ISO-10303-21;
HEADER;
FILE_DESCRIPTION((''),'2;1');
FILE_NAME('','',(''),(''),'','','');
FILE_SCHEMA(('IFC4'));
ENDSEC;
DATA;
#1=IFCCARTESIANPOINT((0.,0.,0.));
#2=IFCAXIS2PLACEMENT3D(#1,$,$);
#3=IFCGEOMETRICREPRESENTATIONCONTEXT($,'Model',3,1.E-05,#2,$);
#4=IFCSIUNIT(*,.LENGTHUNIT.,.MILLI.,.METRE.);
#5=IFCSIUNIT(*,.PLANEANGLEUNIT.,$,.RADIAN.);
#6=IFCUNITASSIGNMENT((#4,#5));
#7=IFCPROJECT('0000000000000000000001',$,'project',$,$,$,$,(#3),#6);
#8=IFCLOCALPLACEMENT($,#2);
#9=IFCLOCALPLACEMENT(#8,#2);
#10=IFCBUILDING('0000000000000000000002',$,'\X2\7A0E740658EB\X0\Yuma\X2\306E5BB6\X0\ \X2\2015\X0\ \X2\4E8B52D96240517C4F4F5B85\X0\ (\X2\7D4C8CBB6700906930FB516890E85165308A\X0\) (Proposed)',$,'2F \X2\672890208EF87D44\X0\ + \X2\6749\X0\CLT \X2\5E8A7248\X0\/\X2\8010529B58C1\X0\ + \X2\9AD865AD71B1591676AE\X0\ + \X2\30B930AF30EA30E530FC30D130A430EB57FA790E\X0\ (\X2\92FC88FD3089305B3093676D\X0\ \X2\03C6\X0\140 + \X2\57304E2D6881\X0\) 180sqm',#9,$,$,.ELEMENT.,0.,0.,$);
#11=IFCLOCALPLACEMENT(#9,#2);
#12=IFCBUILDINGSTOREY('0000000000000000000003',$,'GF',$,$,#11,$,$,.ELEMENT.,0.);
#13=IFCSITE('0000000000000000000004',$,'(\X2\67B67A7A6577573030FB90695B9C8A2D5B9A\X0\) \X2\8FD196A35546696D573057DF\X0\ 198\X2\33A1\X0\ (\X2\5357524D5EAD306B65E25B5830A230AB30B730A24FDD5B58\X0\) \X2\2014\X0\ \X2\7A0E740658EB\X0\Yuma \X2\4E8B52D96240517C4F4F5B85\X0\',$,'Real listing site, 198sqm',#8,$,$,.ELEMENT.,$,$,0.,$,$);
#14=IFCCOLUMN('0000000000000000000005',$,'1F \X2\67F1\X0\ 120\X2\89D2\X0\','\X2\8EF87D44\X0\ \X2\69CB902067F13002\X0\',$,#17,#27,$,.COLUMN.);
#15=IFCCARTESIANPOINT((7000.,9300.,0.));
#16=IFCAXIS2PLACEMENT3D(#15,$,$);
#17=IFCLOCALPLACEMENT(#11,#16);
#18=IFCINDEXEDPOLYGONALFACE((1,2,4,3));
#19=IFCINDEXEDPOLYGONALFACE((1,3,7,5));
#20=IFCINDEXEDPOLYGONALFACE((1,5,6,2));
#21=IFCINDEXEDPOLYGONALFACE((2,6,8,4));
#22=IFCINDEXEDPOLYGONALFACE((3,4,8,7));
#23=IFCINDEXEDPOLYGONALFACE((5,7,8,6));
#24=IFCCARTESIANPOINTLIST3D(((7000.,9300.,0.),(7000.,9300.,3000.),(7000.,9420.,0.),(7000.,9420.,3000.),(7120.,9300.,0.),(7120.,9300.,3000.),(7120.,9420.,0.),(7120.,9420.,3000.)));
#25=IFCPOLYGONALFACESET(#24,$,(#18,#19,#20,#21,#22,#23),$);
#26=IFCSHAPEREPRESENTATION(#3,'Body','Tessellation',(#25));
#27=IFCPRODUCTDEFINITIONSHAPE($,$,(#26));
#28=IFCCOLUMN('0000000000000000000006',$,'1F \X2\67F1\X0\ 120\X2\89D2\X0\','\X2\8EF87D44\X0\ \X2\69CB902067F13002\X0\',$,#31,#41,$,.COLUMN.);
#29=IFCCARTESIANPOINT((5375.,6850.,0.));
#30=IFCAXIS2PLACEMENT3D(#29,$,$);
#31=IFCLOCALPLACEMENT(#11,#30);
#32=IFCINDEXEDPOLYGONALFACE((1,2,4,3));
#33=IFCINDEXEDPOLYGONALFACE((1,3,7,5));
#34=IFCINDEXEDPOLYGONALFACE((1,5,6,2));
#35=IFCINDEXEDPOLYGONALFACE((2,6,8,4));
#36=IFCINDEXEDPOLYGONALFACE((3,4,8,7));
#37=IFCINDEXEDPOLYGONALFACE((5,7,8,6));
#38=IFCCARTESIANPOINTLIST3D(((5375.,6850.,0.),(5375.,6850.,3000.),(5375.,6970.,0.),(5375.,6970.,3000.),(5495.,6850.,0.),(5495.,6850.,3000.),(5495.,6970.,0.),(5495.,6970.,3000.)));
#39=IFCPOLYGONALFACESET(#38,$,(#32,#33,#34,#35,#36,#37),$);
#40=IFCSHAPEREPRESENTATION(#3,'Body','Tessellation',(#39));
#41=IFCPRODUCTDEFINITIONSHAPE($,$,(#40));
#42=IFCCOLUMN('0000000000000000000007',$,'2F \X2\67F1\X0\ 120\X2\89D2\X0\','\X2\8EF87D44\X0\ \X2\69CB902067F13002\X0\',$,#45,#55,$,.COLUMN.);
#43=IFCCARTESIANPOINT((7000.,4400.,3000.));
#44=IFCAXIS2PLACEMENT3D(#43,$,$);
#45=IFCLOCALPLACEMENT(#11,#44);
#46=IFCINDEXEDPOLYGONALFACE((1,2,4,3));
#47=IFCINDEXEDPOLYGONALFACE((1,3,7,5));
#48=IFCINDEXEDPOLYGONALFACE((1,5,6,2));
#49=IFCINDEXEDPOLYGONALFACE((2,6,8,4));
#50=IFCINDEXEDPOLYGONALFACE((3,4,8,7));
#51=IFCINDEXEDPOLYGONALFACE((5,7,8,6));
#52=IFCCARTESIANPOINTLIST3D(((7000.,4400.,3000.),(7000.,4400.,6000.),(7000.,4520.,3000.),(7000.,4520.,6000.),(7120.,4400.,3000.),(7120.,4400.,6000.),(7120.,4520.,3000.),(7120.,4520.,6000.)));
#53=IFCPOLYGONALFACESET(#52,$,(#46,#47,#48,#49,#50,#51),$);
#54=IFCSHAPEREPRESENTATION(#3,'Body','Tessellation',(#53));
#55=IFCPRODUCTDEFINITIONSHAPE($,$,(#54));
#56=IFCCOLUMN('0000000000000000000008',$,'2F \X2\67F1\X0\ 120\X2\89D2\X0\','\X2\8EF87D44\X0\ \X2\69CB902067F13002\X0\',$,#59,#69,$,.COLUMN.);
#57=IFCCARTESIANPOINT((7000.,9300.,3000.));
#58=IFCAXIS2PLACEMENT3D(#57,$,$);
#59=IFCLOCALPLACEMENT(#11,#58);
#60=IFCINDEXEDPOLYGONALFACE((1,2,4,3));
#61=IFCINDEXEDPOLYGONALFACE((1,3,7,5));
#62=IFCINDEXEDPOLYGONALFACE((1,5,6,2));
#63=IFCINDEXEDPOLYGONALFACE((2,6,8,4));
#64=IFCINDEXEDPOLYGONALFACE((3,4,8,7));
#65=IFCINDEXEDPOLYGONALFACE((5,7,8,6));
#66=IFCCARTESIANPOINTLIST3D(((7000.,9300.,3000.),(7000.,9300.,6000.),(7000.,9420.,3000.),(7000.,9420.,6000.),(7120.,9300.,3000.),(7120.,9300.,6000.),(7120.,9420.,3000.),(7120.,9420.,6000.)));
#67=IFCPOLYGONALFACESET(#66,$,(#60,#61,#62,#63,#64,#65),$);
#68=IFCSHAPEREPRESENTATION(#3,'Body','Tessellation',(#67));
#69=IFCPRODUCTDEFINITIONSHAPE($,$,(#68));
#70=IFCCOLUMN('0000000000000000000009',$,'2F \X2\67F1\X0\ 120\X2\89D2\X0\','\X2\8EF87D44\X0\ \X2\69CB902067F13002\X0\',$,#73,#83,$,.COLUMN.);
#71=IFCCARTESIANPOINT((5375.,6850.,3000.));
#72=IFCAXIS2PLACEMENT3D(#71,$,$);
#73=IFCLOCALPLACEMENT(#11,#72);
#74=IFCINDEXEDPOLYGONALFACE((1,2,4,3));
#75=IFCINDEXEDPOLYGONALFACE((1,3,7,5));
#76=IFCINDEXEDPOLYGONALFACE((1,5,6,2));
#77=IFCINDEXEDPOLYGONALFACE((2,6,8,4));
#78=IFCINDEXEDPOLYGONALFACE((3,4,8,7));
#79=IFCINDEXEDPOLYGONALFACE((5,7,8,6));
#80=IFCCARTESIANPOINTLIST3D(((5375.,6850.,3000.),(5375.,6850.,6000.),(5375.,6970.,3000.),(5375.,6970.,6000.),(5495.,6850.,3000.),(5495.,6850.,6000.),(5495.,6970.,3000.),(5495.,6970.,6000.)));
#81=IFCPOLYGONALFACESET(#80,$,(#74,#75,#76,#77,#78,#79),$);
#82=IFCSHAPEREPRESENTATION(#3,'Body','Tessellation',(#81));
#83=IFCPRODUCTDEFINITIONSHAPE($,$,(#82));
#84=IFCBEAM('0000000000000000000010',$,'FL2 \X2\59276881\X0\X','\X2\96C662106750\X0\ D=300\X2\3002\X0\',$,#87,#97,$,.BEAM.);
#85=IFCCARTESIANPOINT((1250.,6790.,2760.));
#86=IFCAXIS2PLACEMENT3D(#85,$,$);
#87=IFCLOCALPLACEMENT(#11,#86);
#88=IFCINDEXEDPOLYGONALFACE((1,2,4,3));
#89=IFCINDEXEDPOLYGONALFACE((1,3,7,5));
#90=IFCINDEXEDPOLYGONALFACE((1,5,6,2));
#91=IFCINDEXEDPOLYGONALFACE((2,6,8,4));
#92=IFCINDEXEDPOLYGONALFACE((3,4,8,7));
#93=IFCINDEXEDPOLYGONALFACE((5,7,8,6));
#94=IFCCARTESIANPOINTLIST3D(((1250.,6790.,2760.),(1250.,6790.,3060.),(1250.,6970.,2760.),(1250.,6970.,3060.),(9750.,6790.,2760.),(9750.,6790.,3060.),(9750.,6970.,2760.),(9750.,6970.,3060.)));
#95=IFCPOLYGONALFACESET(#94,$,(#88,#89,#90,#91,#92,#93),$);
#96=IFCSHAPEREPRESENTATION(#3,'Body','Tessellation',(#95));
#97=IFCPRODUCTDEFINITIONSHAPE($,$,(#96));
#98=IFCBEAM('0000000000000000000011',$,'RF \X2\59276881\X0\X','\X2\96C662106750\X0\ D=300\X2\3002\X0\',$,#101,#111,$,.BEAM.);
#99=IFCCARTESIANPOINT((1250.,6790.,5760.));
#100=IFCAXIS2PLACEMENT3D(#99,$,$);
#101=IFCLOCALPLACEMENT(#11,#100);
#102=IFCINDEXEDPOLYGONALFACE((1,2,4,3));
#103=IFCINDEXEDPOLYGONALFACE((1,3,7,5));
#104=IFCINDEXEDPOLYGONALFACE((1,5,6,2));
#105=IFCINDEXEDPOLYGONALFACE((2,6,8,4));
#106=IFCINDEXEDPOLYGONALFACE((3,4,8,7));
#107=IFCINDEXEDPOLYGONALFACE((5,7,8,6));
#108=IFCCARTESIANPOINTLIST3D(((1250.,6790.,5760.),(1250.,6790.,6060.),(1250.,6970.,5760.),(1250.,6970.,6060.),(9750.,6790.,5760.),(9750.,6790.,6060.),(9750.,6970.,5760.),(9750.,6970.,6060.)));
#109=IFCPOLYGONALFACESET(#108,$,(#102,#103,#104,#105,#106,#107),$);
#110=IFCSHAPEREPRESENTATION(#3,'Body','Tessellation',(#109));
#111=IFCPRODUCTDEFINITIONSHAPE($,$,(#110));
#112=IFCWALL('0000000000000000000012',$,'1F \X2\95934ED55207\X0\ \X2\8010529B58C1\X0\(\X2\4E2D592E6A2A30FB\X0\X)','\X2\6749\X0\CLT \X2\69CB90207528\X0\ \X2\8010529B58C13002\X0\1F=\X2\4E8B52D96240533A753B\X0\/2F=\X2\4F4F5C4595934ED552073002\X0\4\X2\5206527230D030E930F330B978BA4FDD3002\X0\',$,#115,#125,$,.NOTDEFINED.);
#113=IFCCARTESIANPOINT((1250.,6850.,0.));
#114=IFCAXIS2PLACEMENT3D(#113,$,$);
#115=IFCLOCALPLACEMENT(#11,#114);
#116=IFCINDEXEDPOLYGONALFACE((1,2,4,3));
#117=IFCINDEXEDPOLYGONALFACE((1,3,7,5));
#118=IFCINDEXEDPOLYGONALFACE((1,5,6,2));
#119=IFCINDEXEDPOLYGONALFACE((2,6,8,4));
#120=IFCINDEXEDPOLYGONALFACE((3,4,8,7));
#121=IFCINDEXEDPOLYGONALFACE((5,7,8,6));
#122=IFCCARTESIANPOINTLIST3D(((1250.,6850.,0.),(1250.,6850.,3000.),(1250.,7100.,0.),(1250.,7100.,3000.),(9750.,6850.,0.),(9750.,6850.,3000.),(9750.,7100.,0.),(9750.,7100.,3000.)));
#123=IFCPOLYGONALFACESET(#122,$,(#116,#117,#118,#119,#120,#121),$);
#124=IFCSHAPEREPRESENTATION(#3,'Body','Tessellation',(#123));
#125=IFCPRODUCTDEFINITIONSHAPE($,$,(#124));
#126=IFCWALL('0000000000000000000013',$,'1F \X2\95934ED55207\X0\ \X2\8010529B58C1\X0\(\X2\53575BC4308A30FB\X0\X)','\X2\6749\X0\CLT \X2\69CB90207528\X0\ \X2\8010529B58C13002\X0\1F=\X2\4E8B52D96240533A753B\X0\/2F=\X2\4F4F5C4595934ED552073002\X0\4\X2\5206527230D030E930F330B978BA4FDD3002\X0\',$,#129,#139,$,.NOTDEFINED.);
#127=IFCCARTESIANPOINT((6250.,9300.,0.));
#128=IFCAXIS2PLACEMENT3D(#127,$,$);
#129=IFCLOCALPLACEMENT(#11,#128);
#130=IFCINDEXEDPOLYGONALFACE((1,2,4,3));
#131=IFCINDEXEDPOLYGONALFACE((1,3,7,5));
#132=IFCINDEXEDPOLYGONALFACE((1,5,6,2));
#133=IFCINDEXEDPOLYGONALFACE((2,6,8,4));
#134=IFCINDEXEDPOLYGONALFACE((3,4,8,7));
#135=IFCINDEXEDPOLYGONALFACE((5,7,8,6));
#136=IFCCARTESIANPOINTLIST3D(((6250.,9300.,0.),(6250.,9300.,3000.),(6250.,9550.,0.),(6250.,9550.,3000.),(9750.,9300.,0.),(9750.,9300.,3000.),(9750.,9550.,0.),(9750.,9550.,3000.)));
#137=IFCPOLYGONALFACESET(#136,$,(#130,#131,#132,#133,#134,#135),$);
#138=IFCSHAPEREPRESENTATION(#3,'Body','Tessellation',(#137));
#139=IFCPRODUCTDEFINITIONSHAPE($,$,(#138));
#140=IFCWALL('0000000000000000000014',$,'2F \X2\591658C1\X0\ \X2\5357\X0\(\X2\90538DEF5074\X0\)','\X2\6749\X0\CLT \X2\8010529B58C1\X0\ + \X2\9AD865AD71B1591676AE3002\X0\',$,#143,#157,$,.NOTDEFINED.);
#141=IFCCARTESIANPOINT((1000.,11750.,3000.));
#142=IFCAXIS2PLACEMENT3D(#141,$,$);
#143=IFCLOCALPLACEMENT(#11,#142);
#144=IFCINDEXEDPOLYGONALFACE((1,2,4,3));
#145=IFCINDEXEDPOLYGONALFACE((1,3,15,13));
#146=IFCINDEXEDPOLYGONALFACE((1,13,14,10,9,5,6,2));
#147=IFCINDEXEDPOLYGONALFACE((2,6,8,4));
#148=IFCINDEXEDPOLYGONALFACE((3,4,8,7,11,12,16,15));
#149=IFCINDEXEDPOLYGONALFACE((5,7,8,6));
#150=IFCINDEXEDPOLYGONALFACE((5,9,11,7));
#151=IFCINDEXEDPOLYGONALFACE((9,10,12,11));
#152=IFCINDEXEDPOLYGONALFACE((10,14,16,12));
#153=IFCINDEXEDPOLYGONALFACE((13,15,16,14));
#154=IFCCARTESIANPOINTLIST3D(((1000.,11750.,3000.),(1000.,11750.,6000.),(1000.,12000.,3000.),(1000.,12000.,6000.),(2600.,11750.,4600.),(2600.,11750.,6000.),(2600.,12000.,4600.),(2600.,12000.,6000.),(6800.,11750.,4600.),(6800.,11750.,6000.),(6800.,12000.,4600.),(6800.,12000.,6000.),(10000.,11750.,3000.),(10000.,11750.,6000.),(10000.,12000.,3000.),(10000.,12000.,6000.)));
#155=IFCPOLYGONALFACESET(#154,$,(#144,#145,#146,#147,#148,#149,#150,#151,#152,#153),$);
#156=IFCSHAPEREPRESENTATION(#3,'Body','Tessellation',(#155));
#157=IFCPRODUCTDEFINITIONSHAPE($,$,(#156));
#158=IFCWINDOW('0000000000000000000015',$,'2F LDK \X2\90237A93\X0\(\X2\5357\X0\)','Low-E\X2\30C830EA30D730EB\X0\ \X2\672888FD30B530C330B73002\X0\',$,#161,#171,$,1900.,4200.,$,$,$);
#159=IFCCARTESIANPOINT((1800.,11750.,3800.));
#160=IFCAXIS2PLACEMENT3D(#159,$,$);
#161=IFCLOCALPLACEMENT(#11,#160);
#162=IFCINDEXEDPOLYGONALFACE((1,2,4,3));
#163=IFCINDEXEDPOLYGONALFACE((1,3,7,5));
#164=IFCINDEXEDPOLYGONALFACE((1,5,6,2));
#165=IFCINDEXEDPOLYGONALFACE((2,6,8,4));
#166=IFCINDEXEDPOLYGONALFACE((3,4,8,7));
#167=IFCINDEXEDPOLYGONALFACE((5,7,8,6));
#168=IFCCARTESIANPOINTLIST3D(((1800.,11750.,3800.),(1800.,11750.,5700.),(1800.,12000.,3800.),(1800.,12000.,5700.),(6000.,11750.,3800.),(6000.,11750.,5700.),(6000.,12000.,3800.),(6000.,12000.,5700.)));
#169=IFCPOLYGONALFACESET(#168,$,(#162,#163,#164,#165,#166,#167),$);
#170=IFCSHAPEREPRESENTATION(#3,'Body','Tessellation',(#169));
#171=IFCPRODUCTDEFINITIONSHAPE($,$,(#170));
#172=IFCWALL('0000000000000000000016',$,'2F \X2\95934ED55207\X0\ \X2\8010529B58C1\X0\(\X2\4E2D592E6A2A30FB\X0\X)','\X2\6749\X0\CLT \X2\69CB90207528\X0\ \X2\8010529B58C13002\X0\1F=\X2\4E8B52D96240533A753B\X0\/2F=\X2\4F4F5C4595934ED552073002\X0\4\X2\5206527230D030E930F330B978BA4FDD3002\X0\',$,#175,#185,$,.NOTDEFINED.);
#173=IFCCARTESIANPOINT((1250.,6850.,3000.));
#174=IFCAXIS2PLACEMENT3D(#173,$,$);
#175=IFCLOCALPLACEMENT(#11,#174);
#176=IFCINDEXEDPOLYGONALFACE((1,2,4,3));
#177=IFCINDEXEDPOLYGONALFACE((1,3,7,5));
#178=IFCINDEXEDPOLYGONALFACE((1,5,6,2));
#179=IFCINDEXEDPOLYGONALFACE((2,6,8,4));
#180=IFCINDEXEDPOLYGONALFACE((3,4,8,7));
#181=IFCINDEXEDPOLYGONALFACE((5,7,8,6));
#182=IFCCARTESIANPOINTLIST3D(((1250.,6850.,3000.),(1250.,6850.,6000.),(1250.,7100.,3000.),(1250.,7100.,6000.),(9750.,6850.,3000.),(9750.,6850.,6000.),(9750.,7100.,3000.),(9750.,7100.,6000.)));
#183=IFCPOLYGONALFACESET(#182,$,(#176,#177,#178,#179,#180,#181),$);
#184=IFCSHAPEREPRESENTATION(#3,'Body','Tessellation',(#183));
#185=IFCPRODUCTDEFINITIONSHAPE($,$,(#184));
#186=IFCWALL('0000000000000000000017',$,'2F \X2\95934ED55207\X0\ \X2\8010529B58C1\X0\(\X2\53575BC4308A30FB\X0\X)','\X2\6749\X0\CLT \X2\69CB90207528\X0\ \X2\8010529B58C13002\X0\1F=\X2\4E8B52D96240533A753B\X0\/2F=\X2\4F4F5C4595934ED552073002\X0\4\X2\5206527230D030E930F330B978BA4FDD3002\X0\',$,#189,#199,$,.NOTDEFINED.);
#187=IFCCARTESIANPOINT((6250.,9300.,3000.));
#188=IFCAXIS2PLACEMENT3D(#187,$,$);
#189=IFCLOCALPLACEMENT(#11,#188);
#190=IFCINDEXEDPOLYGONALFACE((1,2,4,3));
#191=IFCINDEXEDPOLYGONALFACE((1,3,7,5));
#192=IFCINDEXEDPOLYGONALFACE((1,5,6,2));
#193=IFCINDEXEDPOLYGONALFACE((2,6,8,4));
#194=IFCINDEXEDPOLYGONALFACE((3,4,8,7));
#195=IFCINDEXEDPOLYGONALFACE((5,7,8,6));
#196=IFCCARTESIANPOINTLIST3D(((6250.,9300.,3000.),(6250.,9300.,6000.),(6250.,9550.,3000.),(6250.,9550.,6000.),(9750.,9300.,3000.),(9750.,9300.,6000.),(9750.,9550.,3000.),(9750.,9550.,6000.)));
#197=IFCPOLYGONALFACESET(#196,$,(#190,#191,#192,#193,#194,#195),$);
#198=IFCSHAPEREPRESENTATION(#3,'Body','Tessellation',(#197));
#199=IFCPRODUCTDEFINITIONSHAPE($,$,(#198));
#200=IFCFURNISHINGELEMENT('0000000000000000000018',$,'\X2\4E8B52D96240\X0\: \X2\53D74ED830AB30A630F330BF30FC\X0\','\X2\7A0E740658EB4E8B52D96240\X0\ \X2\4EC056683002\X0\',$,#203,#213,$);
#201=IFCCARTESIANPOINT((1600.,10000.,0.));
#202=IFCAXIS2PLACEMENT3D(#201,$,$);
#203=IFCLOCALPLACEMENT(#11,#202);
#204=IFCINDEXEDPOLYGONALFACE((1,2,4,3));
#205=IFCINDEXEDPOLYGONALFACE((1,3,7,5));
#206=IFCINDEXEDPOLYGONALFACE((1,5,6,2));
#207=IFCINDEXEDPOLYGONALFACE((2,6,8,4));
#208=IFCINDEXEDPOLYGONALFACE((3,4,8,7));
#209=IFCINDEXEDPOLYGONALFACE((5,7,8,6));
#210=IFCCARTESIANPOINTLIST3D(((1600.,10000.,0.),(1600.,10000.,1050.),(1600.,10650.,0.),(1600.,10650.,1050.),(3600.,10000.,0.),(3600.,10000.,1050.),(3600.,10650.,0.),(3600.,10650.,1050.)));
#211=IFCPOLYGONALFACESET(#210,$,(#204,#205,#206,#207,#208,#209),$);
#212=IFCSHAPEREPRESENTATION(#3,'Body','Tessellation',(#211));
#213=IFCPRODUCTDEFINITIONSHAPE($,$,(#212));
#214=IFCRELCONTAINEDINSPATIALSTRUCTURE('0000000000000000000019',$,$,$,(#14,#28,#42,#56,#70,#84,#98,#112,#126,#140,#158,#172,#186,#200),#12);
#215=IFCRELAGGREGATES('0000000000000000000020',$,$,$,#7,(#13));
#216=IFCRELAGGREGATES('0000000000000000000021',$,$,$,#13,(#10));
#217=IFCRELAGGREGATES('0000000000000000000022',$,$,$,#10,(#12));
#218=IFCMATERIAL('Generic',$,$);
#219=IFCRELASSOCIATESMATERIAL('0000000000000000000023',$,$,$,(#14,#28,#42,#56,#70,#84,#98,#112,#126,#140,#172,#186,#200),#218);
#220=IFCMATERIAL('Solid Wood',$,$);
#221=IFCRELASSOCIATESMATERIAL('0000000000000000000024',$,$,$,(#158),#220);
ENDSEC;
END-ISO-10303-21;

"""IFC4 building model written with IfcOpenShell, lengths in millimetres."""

from ifc_helpers import new_model, si_unit, frame, frame_2d, origin, place, context, project, spatial, rectangle, extrude, material, element, fill, save


model = new_model("IFC4")

# Units and contexts
model_context = context("Model", 3, precision=1e-05, world=origin())
ifc_project = project(units=[si_unit("LENGTHUNIT", "METRE", prefix="MILLI"), si_unit("PLANEANGLEUNIT", "RADIAN")], contexts=[model_context])

# Site, building, storey
site_placement = place(None, origin())
site = spatial("IfcSite", under=ifc_project, at=site_placement, Name="(架空敷地・適宜設定) 近隣商業地域 198㎡ (南前庭に既存アカシア保存) — 税理士Yuma 事務所兼住宅", ObjectType="Real listing site, 198sqm", CompositionType="ELEMENT", RefElevation=0.0)
building_placement = place(site_placement, origin())
building = spatial("IfcBuilding", under=site, at=building_placement, Name="税理士Yumaの家 ― 事務所兼住宅 (経費最適・全部入り) (Proposed)", ObjectType="2F 木造軸組 + 杉CLT 床版/耐力壁 + 高断熱外皮 + スクリューパイル基礎 (鋼製らせん杭 φ140 + 地中梁) 180sqm", CompositionType="ELEMENT", ElevationOfRefHeight=0.0, ElevationOfTerrain=0.0)
storey_placement = place(building_placement, origin())
storey = spatial("IfcBuildingStorey", under=building, at=storey_placement, Name="GF", CompositionType="ELEMENT", Elevation=0.0)

# Columns
ifc_material_1 = material(Name="Generic")
column_1_placement = place(storey_placement, frame((7000.0, 9300.0, 0.0)))
element("IfcColumn", 1, at=column_1_placement, inside=storey, material=ifc_material_1, Name="1F 柱 120角", Description="軸組 構造柱。", PredefinedType="COLUMN", context=model_context, shape_type="SweptSolid", body=[
    extrude(rectangle(XDim=120.0, YDim=120.0, at=frame_2d((60.0, 60.0))), frame((7000.0, 9300.0, 0.0)), (0.0, 0.0, 1.0), 3000.0),
])
column_2_placement = place(storey_placement, frame((5375.0, 6850.0, 0.0)))
element("IfcColumn", 2, at=column_2_placement, inside=storey, material=ifc_material_1, Name="1F 柱 120角", Description="軸組 構造柱。", PredefinedType="COLUMN", context=model_context, shape_type="SweptSolid", body=[
    extrude(rectangle(XDim=120.0, YDim=120.0, at=frame_2d((60.0, 60.0))), frame((5375.0, 6850.0, 0.0)), (0.0, 0.0, 1.0), 3000.0),
])
column_3_placement = place(storey_placement, frame((7000.0, 4400.0, 3000.0)))
element("IfcColumn", 3, at=column_3_placement, inside=storey, material=ifc_material_1, Name="2F 柱 120角", Description="軸組 構造柱。", PredefinedType="COLUMN", context=model_context, shape_type="SweptSolid", body=[
    extrude(rectangle(XDim=120.0, YDim=120.0, at=frame_2d((60.0, 60.0))), frame((7000.0, 4400.0, 3000.0)), (0.0, 0.0, 1.0), 3000.0),
])
column_4_placement = place(storey_placement, frame((7000.0, 9300.0, 3000.0)))
element("IfcColumn", 4, at=column_4_placement, inside=storey, material=ifc_material_1, Name="2F 柱 120角", Description="軸組 構造柱。", PredefinedType="COLUMN", context=model_context, shape_type="SweptSolid", body=[
    extrude(rectangle(XDim=120.0, YDim=120.0, at=frame_2d((60.0, 60.0))), frame((7000.0, 9300.0, 3000.0)), (0.0, 0.0, 1.0), 3000.0),
])
column_5_placement = place(storey_placement, frame((5375.0, 6850.0, 3000.0)))
element("IfcColumn", 5, at=column_5_placement, inside=storey, material=ifc_material_1, Name="2F 柱 120角", Description="軸組 構造柱。", PredefinedType="COLUMN", context=model_context, shape_type="SweptSolid", body=[
    extrude(rectangle(XDim=120.0, YDim=120.0, at=frame_2d((60.0, 60.0))), frame((5375.0, 6850.0, 3000.0)), (0.0, 0.0, 1.0), 3000.0),
])

# Beams
beam_1_placement = place(storey_placement, frame((1250.0, 6790.0, 2760.0)))
element("IfcBeam", 6, at=beam_1_placement, inside=storey, material=ifc_material_1, Name="FL2 大梁X", Description="集成材 D=300。", PredefinedType="BEAM", context=model_context, shape_type="SweptSolid", body=[
    extrude(rectangle(XDim=8500.0, YDim=180.0, at=frame_2d((4250.0, 90.0))), frame((1250.0, 6790.0, 2760.0)), (0.0, 0.0, 1.0), 300.0),
])
beam_2_placement = place(storey_placement, frame((1250.0, 6790.0, 5760.0)))
element("IfcBeam", 7, at=beam_2_placement, inside=storey, material=ifc_material_1, Name="RF 大梁X", Description="集成材 D=300。", PredefinedType="BEAM", context=model_context, shape_type="SweptSolid", body=[
    extrude(rectangle(XDim=8500.0, YDim=180.0, at=frame_2d((4250.0, 90.0))), frame((1250.0, 6790.0, 5760.0)), (0.0, 0.0, 1.0), 300.0),
])

# Shared definitions
ifc_material_2 = material(Name="Solid Wood")

# Walls
wall_1_placement = place(storey_placement, frame((1250.0, 6850.0, 0.0)))
element("IfcWall", 8, at=wall_1_placement, inside=storey, material=ifc_material_1, Name="1F 間仕切 耐力壁(中央横・X)", Description="杉CLT 構造用 耐力壁。1F=事務所区画/2F=住居間仕切。4分割バランス確保。", PredefinedType="NOTDEFINED", context=model_context, shape_type="SweptSolid", body=[
    extrude(rectangle(XDim=8500.0, YDim=250.0, at=frame_2d((4250.0, 125.0))), frame((1250.0, 6850.0, 0.0)), (0.0, 0.0, 1.0), 3000.0),
])
wall_2_placement = place(storey_placement, frame((6250.0, 9300.0, 0.0)))
element("IfcWall", 9, at=wall_2_placement, inside=storey, material=ifc_material_1, Name="1F 間仕切 耐力壁(南寄り・X)", Description="杉CLT 構造用 耐力壁。1F=事務所区画/2F=住居間仕切。4分割バランス確保。", PredefinedType="NOTDEFINED", context=model_context, shape_type="SweptSolid", body=[
    extrude(rectangle(XDim=3500.0, YDim=250.0, at=frame_2d((1750.0, 125.0))), frame((6250.0, 9300.0, 0.0)), (0.0, 0.0, 1.0), 3000.0),
])

# Wall, opening, window
wall_3_placement = place(storey_placement, frame((1000.0, 11750.0, 3000.0)))
wall_3 = element("IfcWall", 10, at=wall_3_placement, inside=storey, material=ifc_material_1, Name="2F 外壁 南(道路側)", Description="杉CLT 耐力壁 + 高断熱外皮。", PredefinedType="NOTDEFINED", context=model_context, shape_type="SweptSolid", body=[
    extrude(rectangle(XDim=9000.0, YDim=250.0, at=frame_2d((4500.0, 125.0))), frame((1000.0, 11750.0, 3000.0)), (0.0, 0.0, 1.0), 3000.0),
])
opening_1_placement = place(storey_placement, frame((1800.0, 11750.0, 3800.0)))
opening_1 = element("IfcOpeningElement", 11, at=opening_1_placement, cuts=wall_3, PredefinedType="NOTDEFINED", context=model_context, shape_type="SweptSolid", body=[
    extrude(rectangle(XDim=4200.0, YDim=250.0, at=frame_2d((2100.0, 125.0))), frame((1800.0, 11750.0, 3800.0)), (0.0, 0.0, 1.0), 1900.0),
])
window_1_placement = place(storey_placement, frame((1800.0, 11750.0, 3800.0)))
window_1 = element("IfcWindow", 12, at=window_1_placement, inside=storey, material=ifc_material_2, Name="2F LDK 連窓(南)", Description="Low-Eトリプル 木製サッシ。", OverallHeight=1900.0, OverallWidth=4200.0, context=model_context, shape_type="SweptSolid", body=[
    extrude(rectangle(XDim=4200.0, YDim=250.0, at=frame_2d((2100.0, 125.0))), frame((1800.0, 11750.0, 3800.0)), (0.0, 0.0, 1.0), 1900.0),
])
fill(opening_1, window_1)

# Walls
wall_4_placement = place(storey_placement, frame((1250.0, 6850.0, 3000.0)))
element("IfcWall", 13, at=wall_4_placement, inside=storey, material=ifc_material_1, Name="2F 間仕切 耐力壁(中央横・X)", Description="杉CLT 構造用 耐力壁。1F=事務所区画/2F=住居間仕切。4分割バランス確保。", PredefinedType="NOTDEFINED", context=model_context, shape_type="SweptSolid", body=[
    extrude(rectangle(XDim=8500.0, YDim=250.0, at=frame_2d((4250.0, 125.0))), frame((1250.0, 6850.0, 3000.0)), (0.0, 0.0, 1.0), 3000.0),
])
wall_5_placement = place(storey_placement, frame((6250.0, 9300.0, 3000.0)))
element("IfcWall", 14, at=wall_5_placement, inside=storey, material=ifc_material_1, Name="2F 間仕切 耐力壁(南寄り・X)", Description="杉CLT 構造用 耐力壁。1F=事務所区画/2F=住居間仕切。4分割バランス確保。", PredefinedType="NOTDEFINED", context=model_context, shape_type="SweptSolid", body=[
    extrude(rectangle(XDim=3500.0, YDim=250.0, at=frame_2d((1750.0, 125.0))), frame((6250.0, 9300.0, 3000.0)), (0.0, 0.0, 1.0), 3000.0),
])

# Furnishing element
furnishing_1_placement = place(storey_placement, frame((1600.0, 10000.0, 0.0)))
element("IfcFurnishingElement", 15, at=furnishing_1_placement, inside=storey, material=ifc_material_1, Name="事務所: 受付カウンター", Description="税理士事務所 什器。", context=model_context, shape_type="SweptSolid", body=[
    extrude(rectangle(XDim=2000.0, YDim=650.0, at=frame_2d((1000.0, 325.0))), frame((1600.0, 10000.0, 0.0)), (0.0, 0.0, 1.0), 1050.0),
])

save(model, "model.ifc")
